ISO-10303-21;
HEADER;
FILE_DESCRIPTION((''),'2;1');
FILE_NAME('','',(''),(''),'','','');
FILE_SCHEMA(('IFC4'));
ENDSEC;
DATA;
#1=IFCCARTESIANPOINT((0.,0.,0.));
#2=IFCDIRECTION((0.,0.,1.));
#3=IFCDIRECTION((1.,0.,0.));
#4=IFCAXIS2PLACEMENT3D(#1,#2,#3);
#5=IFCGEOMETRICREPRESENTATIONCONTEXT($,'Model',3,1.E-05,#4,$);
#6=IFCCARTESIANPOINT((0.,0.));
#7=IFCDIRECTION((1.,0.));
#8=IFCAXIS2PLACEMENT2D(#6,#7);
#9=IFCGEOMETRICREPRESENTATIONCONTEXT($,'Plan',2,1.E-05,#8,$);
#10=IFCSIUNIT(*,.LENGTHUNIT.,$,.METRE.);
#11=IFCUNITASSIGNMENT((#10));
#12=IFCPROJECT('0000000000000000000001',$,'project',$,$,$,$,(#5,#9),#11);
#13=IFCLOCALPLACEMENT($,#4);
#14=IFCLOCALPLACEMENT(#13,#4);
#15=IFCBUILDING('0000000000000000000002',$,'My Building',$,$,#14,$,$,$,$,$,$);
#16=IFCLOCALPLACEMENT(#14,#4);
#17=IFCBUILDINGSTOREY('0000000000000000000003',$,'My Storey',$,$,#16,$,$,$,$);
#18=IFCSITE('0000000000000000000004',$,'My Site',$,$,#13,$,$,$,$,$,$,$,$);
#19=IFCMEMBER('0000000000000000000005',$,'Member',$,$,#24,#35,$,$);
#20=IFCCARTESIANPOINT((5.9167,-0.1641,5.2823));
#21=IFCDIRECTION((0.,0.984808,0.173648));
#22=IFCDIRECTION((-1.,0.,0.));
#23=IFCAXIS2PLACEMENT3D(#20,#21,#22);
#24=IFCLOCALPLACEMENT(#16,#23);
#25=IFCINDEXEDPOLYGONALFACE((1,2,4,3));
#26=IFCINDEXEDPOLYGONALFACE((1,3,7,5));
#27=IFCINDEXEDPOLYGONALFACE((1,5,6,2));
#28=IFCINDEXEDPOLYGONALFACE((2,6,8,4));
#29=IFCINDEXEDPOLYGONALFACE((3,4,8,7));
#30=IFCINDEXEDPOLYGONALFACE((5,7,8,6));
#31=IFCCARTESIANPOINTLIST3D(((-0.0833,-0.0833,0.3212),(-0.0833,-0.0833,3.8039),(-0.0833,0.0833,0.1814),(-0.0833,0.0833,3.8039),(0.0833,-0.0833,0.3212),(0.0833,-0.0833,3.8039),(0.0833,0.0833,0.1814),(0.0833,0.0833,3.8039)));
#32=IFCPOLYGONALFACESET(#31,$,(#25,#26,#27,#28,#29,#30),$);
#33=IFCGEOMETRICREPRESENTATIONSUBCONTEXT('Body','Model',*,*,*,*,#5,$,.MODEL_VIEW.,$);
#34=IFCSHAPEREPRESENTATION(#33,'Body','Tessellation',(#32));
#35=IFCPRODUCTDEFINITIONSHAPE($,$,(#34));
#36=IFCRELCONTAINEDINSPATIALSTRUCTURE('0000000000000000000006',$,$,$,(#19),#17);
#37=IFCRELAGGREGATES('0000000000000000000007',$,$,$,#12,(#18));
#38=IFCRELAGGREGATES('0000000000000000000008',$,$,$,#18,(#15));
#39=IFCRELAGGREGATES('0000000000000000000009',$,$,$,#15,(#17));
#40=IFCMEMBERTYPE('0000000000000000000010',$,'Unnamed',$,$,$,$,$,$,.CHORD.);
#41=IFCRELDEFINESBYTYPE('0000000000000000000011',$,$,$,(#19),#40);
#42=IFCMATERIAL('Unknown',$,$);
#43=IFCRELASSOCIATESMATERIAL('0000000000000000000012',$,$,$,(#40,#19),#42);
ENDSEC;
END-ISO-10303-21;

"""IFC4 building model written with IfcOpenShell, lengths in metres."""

from ifc_helpers import new_model, si_unit, frame, origin_with_axes, origin_2d_with_axis, place, context, subcontext, project, spatial, rectangle, extrude, clip, halfspace, material, material_profile, profile_set, profile_usage, type_object, element, save


model = new_model("IFC4")

# Units and contexts
model_context = context("Model", 3, precision=1e-05, world=origin_with_axes())
plan_context = context("Plan", 2, precision=1e-05, world=origin_2d_with_axis())
body_context = subcontext(model_context, "Body", "Model", "MODEL_VIEW")
ifc_project = project(units=[si_unit("LENGTHUNIT", "METRE")], contexts=[model_context, plan_context])

# Site, building, storey
site_placement = place(None, origin_with_axes())
site = spatial("IfcSite", under=ifc_project, at=site_placement, Name="My Site")
building_placement = place(site_placement, origin_with_axes())
building = spatial("IfcBuilding", under=site, at=building_placement, Name="My Building")
storey_placement = place(building_placement, origin_with_axes())
storey = spatial("IfcBuildingStorey", under=building, at=storey_placement, Name="My Storey")

# Shared definitions
ifc_material = material(Name="Unknown")

# Member
ifc_material_profile_1 = material_profile(ifc_material, rectangle(XDim=0.1667, YDim=0.1667))
ifc_profile_set_1 = profile_set([ifc_material_profile_1])
member_type = type_object("IfcMemberType", Name="Unnamed", PredefinedType="CHORD", material=ifc_profile_set_1)
ifc_profile_usage_1 = profile_usage(ifc_profile_set_1, cardinal=5)
member_1_placement = place(storey_placement, frame((5.9167, -0.1641, 5.2823), z_axis=(0.0, 0.984808, 0.173648), x_axis=(-1.0, 0.0, 0.0)))
element("IfcMember", 1, at=member_1_placement, inside=storey, type_object=member_type, material=ifc_profile_usage_1, Name="Member", context=body_context, shape_type="Clipping", body=[
    clip(extrude(rectangle(XDim=0.1667, YDim=0.1667), origin_with_axes(), (0.0, 0.0, 1.0), 3.8039), halfspace(frame((4.5833, 0.0833, 0.1814), z_axis=(0.0, -0.642788, -0.766045), x_axis=(-1.0, 0.0, 0.0)), False)),
])

save(model, "model.ifc")
